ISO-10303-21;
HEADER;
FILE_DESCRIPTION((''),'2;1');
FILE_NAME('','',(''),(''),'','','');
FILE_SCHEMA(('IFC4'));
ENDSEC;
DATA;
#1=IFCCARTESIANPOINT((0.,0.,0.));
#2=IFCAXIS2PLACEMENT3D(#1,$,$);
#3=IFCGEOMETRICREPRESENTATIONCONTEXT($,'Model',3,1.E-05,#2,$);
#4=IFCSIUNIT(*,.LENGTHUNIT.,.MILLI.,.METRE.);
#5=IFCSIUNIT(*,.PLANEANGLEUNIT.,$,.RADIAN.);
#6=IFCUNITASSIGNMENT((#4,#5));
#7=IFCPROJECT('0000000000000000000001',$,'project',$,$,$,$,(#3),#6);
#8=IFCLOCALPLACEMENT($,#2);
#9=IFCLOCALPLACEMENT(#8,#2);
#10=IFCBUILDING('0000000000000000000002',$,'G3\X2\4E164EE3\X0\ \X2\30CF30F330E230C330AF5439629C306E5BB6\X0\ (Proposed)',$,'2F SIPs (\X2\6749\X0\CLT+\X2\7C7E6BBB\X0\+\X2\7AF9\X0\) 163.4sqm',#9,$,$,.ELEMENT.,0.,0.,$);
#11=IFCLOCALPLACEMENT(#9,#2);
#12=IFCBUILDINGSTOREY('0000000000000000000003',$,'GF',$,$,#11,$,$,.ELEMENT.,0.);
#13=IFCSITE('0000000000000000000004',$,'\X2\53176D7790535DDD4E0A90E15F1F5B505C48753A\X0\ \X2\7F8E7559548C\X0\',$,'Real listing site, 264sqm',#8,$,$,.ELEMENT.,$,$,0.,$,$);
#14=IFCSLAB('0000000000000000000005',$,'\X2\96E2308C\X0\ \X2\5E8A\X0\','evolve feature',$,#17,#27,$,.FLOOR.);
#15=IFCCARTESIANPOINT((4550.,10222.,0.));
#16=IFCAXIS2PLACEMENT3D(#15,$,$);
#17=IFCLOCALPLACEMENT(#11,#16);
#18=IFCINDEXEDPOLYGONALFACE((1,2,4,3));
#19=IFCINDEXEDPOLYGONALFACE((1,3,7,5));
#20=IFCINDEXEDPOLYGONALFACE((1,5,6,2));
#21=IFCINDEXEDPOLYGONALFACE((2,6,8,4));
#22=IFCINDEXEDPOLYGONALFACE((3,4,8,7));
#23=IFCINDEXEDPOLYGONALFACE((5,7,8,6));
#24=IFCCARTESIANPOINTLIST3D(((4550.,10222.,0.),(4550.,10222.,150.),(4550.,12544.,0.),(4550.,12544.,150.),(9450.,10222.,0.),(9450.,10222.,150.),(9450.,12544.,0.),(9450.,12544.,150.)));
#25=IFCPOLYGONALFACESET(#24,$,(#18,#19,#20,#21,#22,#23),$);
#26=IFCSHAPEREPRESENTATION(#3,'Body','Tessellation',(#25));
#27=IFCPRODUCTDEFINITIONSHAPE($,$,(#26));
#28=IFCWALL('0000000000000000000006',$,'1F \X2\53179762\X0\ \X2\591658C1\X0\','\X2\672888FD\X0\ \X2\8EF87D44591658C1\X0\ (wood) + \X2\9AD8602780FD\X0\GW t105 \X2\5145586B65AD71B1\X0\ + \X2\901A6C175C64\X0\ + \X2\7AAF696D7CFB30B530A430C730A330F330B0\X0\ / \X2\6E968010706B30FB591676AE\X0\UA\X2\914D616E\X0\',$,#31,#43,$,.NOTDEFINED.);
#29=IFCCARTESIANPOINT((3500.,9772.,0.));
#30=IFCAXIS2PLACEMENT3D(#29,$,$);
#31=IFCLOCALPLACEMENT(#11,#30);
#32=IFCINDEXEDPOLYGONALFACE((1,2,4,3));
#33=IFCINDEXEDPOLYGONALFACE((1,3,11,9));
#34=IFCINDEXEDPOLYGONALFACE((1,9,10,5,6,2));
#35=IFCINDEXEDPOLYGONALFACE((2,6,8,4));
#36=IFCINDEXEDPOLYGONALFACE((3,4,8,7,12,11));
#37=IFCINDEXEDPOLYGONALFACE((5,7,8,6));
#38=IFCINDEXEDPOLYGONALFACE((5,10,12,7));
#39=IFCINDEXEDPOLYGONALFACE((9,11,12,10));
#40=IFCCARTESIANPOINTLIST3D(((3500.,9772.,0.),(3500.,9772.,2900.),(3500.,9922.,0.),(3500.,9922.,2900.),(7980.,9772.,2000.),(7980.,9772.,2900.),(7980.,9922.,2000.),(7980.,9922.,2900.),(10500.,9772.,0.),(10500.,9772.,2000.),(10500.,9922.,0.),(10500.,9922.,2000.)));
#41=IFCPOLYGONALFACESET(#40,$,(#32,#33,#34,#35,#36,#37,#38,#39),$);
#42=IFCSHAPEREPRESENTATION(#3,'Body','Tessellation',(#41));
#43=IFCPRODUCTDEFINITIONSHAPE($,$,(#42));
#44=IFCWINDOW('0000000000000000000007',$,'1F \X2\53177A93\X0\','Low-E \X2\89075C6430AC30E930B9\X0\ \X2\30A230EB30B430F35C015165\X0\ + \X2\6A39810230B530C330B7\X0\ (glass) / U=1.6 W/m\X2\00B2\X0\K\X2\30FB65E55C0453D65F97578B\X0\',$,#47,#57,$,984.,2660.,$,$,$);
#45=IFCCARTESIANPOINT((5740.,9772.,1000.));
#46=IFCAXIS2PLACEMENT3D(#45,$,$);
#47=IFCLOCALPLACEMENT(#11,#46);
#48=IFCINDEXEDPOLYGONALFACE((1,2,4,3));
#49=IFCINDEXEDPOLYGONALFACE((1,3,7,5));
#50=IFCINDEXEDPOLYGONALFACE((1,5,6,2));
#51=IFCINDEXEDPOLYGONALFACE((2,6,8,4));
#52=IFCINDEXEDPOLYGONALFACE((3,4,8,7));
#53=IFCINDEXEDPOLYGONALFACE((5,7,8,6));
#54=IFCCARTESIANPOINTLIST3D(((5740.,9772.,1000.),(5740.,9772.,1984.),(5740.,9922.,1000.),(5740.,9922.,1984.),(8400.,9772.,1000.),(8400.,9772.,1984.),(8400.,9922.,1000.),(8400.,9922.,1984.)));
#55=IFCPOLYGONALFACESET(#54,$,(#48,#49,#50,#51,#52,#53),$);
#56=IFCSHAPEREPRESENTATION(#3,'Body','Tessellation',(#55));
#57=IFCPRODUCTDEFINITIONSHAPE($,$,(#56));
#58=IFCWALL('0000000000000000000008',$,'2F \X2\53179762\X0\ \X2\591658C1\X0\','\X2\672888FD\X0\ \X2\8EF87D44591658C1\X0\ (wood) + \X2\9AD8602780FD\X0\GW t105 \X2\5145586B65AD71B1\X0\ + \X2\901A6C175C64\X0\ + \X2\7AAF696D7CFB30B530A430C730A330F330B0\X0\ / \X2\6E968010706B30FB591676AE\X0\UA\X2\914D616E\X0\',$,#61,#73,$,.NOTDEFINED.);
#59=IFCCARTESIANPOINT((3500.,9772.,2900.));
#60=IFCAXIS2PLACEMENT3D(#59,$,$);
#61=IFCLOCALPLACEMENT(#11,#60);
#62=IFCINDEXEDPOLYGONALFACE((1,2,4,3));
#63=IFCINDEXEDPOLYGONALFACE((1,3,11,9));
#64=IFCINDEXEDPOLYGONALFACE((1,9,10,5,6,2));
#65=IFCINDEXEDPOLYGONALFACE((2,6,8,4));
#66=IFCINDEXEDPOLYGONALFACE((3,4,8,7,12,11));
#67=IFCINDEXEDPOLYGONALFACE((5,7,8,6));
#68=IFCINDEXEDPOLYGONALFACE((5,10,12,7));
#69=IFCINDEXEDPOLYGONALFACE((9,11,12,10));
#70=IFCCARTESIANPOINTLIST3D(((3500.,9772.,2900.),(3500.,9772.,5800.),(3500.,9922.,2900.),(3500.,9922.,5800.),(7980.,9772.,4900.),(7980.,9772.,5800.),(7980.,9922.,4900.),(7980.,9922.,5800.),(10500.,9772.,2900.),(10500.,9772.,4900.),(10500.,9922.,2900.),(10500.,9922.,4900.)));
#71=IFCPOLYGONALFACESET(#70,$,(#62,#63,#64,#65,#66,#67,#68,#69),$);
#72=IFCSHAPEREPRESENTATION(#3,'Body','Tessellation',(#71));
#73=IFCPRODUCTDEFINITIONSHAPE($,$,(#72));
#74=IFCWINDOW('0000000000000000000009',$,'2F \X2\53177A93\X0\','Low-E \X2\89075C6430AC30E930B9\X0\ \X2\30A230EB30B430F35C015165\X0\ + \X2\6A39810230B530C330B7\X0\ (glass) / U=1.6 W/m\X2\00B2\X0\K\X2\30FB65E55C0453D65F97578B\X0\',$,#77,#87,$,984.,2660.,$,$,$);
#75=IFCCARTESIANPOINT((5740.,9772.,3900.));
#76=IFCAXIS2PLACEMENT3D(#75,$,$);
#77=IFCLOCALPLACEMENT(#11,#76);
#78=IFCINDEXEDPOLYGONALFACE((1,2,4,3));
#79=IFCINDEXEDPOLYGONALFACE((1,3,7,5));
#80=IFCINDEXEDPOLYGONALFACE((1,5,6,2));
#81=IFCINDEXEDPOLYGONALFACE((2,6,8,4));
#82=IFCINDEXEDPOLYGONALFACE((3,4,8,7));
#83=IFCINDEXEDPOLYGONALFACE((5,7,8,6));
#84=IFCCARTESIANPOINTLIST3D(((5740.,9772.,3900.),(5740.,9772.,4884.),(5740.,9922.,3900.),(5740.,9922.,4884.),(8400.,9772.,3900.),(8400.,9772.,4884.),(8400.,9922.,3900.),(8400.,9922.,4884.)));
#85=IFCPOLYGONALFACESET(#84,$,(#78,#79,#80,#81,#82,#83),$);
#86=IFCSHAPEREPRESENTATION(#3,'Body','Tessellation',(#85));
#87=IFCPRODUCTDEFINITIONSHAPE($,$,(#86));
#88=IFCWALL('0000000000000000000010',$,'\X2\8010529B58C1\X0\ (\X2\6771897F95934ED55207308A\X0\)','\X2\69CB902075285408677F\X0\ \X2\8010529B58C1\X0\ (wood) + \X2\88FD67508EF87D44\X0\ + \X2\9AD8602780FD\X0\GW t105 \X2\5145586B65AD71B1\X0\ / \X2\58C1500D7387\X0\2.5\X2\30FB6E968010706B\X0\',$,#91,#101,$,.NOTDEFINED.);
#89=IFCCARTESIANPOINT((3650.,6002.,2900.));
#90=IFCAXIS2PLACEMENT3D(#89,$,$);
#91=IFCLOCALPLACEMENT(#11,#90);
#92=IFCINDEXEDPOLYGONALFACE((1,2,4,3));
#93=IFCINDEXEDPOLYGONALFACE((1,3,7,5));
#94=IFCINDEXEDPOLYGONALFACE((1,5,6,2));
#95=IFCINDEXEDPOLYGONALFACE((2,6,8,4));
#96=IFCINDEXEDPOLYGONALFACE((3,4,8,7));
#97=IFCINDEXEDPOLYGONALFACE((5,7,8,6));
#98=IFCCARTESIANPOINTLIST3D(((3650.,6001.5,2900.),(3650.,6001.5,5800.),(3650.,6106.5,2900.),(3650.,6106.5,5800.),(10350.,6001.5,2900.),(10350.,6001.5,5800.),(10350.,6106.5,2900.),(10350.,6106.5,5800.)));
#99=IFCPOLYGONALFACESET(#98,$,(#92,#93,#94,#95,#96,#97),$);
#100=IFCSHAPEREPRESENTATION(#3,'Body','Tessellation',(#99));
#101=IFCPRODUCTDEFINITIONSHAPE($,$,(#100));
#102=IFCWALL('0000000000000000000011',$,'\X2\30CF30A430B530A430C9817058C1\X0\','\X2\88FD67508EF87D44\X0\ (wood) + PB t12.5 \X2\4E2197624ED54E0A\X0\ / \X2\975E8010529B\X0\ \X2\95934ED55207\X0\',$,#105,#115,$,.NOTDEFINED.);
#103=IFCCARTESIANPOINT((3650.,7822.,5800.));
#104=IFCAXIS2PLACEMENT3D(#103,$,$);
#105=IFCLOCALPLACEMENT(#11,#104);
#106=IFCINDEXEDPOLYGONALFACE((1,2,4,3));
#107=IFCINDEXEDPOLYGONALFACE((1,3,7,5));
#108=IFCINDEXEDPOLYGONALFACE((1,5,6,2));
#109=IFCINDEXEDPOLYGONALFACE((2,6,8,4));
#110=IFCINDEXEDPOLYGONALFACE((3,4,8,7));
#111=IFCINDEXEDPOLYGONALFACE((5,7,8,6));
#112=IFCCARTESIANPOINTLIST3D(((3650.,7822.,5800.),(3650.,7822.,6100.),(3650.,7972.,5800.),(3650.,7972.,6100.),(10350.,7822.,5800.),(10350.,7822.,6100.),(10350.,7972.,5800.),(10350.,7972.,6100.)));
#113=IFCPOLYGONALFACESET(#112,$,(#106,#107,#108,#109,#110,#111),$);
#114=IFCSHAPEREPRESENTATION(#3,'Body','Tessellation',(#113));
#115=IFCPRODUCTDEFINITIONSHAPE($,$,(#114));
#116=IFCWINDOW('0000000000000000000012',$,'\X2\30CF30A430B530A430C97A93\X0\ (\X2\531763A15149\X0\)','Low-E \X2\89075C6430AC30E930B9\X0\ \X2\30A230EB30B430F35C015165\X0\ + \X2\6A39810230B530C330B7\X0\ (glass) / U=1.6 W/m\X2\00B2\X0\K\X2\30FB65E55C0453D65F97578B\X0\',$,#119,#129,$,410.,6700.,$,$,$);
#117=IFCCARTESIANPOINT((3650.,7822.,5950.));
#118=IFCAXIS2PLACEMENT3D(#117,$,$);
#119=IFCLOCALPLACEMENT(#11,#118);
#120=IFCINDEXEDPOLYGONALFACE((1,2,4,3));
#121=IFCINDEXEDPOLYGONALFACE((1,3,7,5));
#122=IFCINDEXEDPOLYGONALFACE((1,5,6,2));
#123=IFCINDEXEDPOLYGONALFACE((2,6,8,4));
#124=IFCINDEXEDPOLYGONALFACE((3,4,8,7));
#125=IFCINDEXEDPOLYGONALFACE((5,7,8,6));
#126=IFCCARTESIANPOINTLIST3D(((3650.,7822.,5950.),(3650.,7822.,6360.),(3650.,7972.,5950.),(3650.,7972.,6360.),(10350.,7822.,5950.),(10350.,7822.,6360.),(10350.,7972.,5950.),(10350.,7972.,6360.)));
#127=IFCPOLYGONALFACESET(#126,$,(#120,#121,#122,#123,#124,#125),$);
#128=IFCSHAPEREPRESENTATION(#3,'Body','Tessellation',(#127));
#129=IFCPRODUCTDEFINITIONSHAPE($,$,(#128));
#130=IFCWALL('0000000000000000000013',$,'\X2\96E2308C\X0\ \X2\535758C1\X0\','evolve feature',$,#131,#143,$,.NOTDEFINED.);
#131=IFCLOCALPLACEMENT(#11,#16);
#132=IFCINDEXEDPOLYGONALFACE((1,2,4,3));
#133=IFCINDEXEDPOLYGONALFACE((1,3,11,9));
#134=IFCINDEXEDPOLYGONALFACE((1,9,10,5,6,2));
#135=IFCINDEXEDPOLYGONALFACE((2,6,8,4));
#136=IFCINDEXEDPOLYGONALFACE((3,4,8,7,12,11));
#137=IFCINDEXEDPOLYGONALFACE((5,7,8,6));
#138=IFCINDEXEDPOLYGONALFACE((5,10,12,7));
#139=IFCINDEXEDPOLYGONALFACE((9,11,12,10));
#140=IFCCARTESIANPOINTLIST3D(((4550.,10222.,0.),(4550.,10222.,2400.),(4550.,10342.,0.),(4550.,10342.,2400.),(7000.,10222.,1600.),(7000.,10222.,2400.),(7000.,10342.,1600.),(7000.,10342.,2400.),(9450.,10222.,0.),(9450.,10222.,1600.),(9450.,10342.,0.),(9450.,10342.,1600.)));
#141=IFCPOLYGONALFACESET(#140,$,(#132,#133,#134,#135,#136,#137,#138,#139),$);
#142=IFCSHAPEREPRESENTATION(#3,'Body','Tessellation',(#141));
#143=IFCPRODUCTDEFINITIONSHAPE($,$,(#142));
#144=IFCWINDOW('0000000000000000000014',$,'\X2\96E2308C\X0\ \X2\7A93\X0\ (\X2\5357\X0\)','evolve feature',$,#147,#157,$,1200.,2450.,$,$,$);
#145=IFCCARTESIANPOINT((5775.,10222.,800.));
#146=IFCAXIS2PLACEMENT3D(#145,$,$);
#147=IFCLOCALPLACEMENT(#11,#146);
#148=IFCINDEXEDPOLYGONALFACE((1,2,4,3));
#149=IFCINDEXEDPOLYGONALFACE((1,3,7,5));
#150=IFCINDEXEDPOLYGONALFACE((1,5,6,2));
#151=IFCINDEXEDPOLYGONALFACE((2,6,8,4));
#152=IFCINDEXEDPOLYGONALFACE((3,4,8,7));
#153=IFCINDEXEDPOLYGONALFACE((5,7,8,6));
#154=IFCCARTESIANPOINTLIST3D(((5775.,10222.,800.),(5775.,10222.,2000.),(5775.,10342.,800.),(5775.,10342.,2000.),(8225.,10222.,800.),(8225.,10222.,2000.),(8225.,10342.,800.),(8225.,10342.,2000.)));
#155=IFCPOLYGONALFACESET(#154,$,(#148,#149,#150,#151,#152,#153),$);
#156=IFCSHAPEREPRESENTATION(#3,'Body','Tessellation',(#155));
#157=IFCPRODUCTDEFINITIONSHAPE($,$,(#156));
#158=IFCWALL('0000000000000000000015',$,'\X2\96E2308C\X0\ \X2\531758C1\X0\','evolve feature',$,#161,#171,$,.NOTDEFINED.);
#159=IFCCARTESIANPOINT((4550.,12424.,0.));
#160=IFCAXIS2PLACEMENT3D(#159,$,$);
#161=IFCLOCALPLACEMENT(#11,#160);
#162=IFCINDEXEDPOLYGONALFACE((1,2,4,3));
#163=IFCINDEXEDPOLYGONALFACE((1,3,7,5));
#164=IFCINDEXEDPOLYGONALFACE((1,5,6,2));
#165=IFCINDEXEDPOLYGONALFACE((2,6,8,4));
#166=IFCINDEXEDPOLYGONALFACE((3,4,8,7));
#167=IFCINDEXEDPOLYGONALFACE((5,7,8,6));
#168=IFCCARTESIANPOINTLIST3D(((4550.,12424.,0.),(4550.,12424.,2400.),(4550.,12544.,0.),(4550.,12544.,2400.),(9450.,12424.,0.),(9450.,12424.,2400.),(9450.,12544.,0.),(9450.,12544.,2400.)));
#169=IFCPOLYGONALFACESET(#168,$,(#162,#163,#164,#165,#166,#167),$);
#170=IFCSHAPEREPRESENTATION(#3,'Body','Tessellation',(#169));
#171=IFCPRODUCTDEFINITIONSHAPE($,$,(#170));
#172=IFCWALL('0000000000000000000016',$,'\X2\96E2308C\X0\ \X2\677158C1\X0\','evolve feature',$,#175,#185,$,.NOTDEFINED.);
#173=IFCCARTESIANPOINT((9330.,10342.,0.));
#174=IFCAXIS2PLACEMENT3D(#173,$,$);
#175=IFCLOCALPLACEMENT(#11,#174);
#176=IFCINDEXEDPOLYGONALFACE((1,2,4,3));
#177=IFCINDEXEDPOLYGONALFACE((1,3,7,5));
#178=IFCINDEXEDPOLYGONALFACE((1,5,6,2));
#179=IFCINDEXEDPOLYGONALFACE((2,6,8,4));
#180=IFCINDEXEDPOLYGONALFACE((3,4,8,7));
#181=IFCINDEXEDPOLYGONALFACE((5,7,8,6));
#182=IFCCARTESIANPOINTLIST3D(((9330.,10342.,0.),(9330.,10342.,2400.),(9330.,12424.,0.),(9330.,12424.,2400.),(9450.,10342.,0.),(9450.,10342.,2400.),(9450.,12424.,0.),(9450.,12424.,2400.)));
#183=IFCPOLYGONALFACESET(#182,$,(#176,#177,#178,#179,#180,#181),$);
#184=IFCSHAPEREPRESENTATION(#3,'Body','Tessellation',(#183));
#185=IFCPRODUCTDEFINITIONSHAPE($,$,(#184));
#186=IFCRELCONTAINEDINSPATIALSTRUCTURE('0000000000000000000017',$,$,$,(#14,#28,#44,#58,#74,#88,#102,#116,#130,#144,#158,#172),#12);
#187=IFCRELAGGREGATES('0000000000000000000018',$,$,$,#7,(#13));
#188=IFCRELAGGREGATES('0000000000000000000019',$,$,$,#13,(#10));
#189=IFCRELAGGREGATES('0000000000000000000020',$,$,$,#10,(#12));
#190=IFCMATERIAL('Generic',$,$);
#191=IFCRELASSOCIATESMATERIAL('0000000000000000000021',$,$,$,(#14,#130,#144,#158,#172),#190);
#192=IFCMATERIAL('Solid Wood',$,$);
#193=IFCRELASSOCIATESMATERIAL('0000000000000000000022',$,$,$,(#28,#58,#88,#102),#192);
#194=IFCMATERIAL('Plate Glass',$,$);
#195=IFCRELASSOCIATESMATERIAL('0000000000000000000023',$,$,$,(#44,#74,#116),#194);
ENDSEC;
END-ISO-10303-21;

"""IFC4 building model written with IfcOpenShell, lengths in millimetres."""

from ifc_helpers import new_model, si_unit, frame, frame_2d, origin, place, context, project, spatial, rectangle, extrude, material, element, fill, save


model = new_model("IFC4")

# Units and contexts
model_context = context("Model", 3, precision=1e-05, world=origin())
ifc_project = project(units=[si_unit("LENGTHUNIT", "METRE", prefix="MILLI"), si_unit("PLANEANGLEUNIT", "RADIAN")], contexts=[model_context])

# Site, building, storey
site_placement = place(None, origin())
site = spatial("IfcSite", under=ifc_project, at=site_placement, Name="北海道川上郡弟子屈町 美留和", ObjectType="Real listing site, 264sqm", CompositionType="ELEMENT", RefElevation=0.0)
building_placement = place(site_placement, origin())
building = spatial("IfcBuilding", under=site, at=building_placement, Name="G3世代 ハンモック吹抜の家 (Proposed)", ObjectType="2F SIPs (杉CLT+籾殻+竹) 163.4sqm", CompositionType="ELEMENT", ElevationOfRefHeight=0.0, ElevationOfTerrain=0.0)
storey_placement = place(building_placement, origin())
storey = spatial("IfcBuildingStorey", under=building, at=storey_placement, Name="GF", CompositionType="ELEMENT", Elevation=0.0)

# Slab
ifc_material_1 = material(Name="Generic")
slab_placement = place(storey_placement, frame((4550.0, 10222.0, 0.0)))
element("IfcSlab", 1, at=slab_placement, inside=storey, material=ifc_material_1, Name="離れ 床", Description="evolve feature", PredefinedType="FLOOR", context=model_context, shape_type="SweptSolid", body=[
    extrude(rectangle(XDim=4900.0, YDim=2322.0, at=frame_2d((2450.0, 1161.0))), frame((4550.0, 10222.0, 0.0)), (0.0, 0.0, 1.0), 150.0),
])

# Wall, opening, window
ifc_material_2 = material(Name="Solid Wood")
wall_1_placement = place(storey_placement, frame((3500.0, 9772.0, 0.0)))
wall_1 = element("IfcWall", 2, at=wall_1_placement, inside=storey, material=ifc_material_2, Name="1F 北面 外壁", Description="木製 軸組外壁 (wood) + 高性能GW t105 充填断熱 + 通気層 + 窯業系サイディング / 準耐火・外皮UA配慮", PredefinedType="NOTDEFINED", context=model_context, shape_type="SweptSolid", body=[
    extrude(rectangle(XDim=7000.0, YDim=150.0, at=frame_2d((3500.0, 75.0))), frame((3500.0, 9772.0, 0.0)), (0.0, 0.0, 1.0), 2900.0),
])
opening_1_placement = place(storey_placement, frame((5740.0, 9772.0, 1000.0)))
opening_1 = element("IfcOpeningElement", 3, at=opening_1_placement, cuts=wall_1, PredefinedType="NOTDEFINED", context=model_context, shape_type="SweptSolid", body=[
    extrude(rectangle(XDim=2660.0, YDim=150.0, at=frame_2d((1330.0, 75.0))), frame((5740.0, 9772.0, 1000.0)), (0.0, 0.0, 1.0), 984.0),
])
ifc_material_3 = material(Name="Plate Glass")
window_1_placement = place(storey_placement, frame((5740.0, 9772.0, 1000.0)))
window_1 = element("IfcWindow", 4, at=window_1_placement, inside=storey, material=ifc_material_3, Name="1F 北窓", Description="Low-E 複層ガラス アルゴン封入 + 樹脂サッシ (glass) / U=1.6 W/m²K・日射取得型", OverallHeight=984.0, OverallWidth=2660.0, context=model_context, shape_type="SweptSolid", body=[
    extrude(rectangle(XDim=2660.0, YDim=150.0, at=frame_2d((1330.0, 75.0))), frame((5740.0, 9772.0, 1000.0)), (0.0, 0.0, 1.0), 984.0),
])
fill(opening_1, window_1)

# Wall, opening, window
wall_2_placement = place(storey_placement, frame((3500.0, 9772.0, 2900.0)))
wall_2 = element("IfcWall", 5, at=wall_2_placement, inside=storey, material=ifc_material_2, Name="2F 北面 外壁", Description="木製 軸組外壁 (wood) + 高性能GW t105 充填断熱 + 通気層 + 窯業系サイディング / 準耐火・外皮UA配慮", PredefinedType="NOTDEFINED", context=model_context, shape_type="SweptSolid", body=[
    extrude(rectangle(XDim=7000.0, YDim=150.0, at=frame_2d((3500.0, 75.0))), frame((3500.0, 9772.0, 2900.0)), (0.0, 0.0, 1.0), 2900.0),
])
opening_2_placement = place(storey_placement, frame((5740.0, 9772.0, 3900.0)))
opening_2 = element("IfcOpeningElement", 6, at=opening_2_placement, cuts=wall_2, PredefinedType="NOTDEFINED", context=model_context, shape_type="SweptSolid", body=[
    extrude(rectangle(XDim=2660.0, YDim=150.0, at=frame_2d((1330.0, 75.0))), frame((5740.0, 9772.0, 3900.0)), (0.0, 0.0, 1.0), 984.0),
])
window_2_placement = place(storey_placement, frame((5740.0, 9772.0, 3900.0)))
window_2 = element("IfcWindow", 7, at=window_2_placement, inside=storey, material=ifc_material_3, Name="2F 北窓", Description="Low-E 複層ガラス アルゴン封入 + 樹脂サッシ (glass) / U=1.6 W/m²K・日射取得型", OverallHeight=984.0, OverallWidth=2660.0, context=model_context, shape_type="SweptSolid", body=[
    extrude(rectangle(XDim=2660.0, YDim=150.0, at=frame_2d((1330.0, 75.0))), frame((5740.0, 9772.0, 3900.0)), (0.0, 0.0, 1.0), 984.0),
])
fill(opening_2, window_2)

# Wall
wall_3_placement = place(storey_placement, frame((3650.0, 6002.0, 2900.0)))
element("IfcWall", 8, at=wall_3_placement, inside=storey, material=ifc_material_2, Name="耐力壁 (東西間仕切り)", Description="構造用合板 耐力壁 (wood) + 製材軸組 + 高性能GW t105 充填断熱 / 壁倍率2.5・準耐火", PredefinedType="NOTDEFINED", context=model_context, shape_type="SweptSolid", body=[
    extrude(rectangle(XDim=6700.0, YDim=105.0, at=frame_2d((3350.0, 52.0))), frame((3650.0, 6002.0, 2900.0)), (0.0, 0.0, 1.0), 2900.0),
])

# Walls, openings, windows
wall_4_placement = place(storey_placement, frame((3650.0, 7822.0, 5800.0)))
wall_4 = element("IfcWall", 9, at=wall_4_placement, inside=storey, material=ifc_material_2, Name="ハイサイド腰壁", Description="製材軸組 (wood) + PB t12.5 両面仕上 / 非耐力 間仕切", PredefinedType="NOTDEFINED", context=model_context, shape_type="SweptSolid", body=[
    extrude(rectangle(XDim=6700.0, YDim=150.0, at=frame_2d((3350.0, 75.0))), frame((3650.0, 7822.0, 5800.0)), (0.0, 0.0, 1.0), 700.0),
])
opening_3_placement = place(storey_placement, frame((3650.0, 7822.0, 5950.0)))
opening_3 = element("IfcOpeningElement", 10, at=opening_3_placement, cuts=wall_4, PredefinedType="NOTDEFINED", context=model_context, shape_type="SweptSolid", body=[
    extrude(rectangle(XDim=6700.0, YDim=150.0, at=frame_2d((3350.0, 75.0))), frame((3650.0, 7822.0, 5950.0)), (0.0, 0.0, 1.0), 410.0),
])
window_3_placement = place(storey_placement, frame((3650.0, 7822.0, 5950.0)))
window_3 = element("IfcWindow", 11, at=window_3_placement, inside=storey, material=ifc_material_3, Name="ハイサイド窓 (北採光)", Description="Low-E 複層ガラス アルゴン封入 + 樹脂サッシ (glass) / U=1.6 W/m²K・日射取得型", OverallHeight=410.0, OverallWidth=6700.0, context=model_context, shape_type="SweptSolid", body=[
    extrude(rectangle(XDim=6700.0, YDim=150.0, at=frame_2d((3350.0, 75.0))), frame((3650.0, 7822.0, 5950.0)), (0.0, 0.0, 1.0), 410.0),
])
fill(opening_3, window_3)
wall_5_placement = place(storey_placement, frame((4550.0, 10222.0, 0.0)))
wall_5 = element("IfcWall", 12, at=wall_5_placement, inside=storey, material=ifc_material_1, Name="離れ 南壁", Description="evolve feature", PredefinedType="NOTDEFINED", context=model_context, shape_type="SweptSolid", body=[
    extrude(rectangle(XDim=4900.0, YDim=120.0, at=frame_2d((2450.0, 60.0))), frame((4550.0, 10222.0, 0.0)), (0.0, 0.0, 1.0), 2400.0),
])
opening_4_placement = place(storey_placement, frame((5775.0, 10222.0, 800.0)))
opening_4 = element("IfcOpeningElement", 13, at=opening_4_placement, cuts=wall_5, PredefinedType="NOTDEFINED", context=model_context, shape_type="SweptSolid", body=[
    extrude(rectangle(XDim=2450.0, YDim=120.0, at=frame_2d((1225.0, 60.0))), frame((5775.0, 10222.0, 800.0)), (0.0, 0.0, 1.0), 1200.0),
])
window_4_placement = place(storey_placement, frame((5775.0, 10222.0, 800.0)))
window_4 = element("IfcWindow", 14, at=window_4_placement, inside=storey, material=ifc_material_1, Name="離れ 窓 (南)", Description="evolve feature", OverallHeight=1200.0, OverallWidth=2450.0, context=model_context, shape_type="SweptSolid", body=[
    extrude(rectangle(XDim=2450.0, YDim=120.0, at=frame_2d((1225.0, 60.0))), frame((5775.0, 10222.0, 800.0)), (0.0, 0.0, 1.0), 1200.0),
])
fill(opening_4, window_4)

# Walls
wall_6_placement = place(storey_placement, frame((4550.0, 12424.0, 0.0)))
element("IfcWall", 15, at=wall_6_placement, inside=storey, material=ifc_material_1, Name="離れ 北壁", Description="evolve feature", PredefinedType="NOTDEFINED", context=model_context, shape_type="SweptSolid", body=[
    extrude(rectangle(XDim=4900.0, YDim=120.0, at=frame_2d((2450.0, 60.0))), frame((4550.0, 12424.0, 0.0)), (0.0, 0.0, 1.0), 2400.0),
])
wall_7_placement = place(storey_placement, frame((9330.0, 10342.0, 0.0)))
element("IfcWall", 16, at=wall_7_placement, inside=storey, material=ifc_material_1, Name="離れ 東壁", Description="evolve feature", PredefinedType="NOTDEFINED", context=model_context, shape_type="SweptSolid", body=[
    extrude(rectangle(XDim=120.0, YDim=2082.0, at=frame_2d((60.0, 1041.0))), frame((9330.0, 10342.0, 0.0)), (0.0, 0.0, 1.0), 2400.0),
])

save(model, "model.ifc")
